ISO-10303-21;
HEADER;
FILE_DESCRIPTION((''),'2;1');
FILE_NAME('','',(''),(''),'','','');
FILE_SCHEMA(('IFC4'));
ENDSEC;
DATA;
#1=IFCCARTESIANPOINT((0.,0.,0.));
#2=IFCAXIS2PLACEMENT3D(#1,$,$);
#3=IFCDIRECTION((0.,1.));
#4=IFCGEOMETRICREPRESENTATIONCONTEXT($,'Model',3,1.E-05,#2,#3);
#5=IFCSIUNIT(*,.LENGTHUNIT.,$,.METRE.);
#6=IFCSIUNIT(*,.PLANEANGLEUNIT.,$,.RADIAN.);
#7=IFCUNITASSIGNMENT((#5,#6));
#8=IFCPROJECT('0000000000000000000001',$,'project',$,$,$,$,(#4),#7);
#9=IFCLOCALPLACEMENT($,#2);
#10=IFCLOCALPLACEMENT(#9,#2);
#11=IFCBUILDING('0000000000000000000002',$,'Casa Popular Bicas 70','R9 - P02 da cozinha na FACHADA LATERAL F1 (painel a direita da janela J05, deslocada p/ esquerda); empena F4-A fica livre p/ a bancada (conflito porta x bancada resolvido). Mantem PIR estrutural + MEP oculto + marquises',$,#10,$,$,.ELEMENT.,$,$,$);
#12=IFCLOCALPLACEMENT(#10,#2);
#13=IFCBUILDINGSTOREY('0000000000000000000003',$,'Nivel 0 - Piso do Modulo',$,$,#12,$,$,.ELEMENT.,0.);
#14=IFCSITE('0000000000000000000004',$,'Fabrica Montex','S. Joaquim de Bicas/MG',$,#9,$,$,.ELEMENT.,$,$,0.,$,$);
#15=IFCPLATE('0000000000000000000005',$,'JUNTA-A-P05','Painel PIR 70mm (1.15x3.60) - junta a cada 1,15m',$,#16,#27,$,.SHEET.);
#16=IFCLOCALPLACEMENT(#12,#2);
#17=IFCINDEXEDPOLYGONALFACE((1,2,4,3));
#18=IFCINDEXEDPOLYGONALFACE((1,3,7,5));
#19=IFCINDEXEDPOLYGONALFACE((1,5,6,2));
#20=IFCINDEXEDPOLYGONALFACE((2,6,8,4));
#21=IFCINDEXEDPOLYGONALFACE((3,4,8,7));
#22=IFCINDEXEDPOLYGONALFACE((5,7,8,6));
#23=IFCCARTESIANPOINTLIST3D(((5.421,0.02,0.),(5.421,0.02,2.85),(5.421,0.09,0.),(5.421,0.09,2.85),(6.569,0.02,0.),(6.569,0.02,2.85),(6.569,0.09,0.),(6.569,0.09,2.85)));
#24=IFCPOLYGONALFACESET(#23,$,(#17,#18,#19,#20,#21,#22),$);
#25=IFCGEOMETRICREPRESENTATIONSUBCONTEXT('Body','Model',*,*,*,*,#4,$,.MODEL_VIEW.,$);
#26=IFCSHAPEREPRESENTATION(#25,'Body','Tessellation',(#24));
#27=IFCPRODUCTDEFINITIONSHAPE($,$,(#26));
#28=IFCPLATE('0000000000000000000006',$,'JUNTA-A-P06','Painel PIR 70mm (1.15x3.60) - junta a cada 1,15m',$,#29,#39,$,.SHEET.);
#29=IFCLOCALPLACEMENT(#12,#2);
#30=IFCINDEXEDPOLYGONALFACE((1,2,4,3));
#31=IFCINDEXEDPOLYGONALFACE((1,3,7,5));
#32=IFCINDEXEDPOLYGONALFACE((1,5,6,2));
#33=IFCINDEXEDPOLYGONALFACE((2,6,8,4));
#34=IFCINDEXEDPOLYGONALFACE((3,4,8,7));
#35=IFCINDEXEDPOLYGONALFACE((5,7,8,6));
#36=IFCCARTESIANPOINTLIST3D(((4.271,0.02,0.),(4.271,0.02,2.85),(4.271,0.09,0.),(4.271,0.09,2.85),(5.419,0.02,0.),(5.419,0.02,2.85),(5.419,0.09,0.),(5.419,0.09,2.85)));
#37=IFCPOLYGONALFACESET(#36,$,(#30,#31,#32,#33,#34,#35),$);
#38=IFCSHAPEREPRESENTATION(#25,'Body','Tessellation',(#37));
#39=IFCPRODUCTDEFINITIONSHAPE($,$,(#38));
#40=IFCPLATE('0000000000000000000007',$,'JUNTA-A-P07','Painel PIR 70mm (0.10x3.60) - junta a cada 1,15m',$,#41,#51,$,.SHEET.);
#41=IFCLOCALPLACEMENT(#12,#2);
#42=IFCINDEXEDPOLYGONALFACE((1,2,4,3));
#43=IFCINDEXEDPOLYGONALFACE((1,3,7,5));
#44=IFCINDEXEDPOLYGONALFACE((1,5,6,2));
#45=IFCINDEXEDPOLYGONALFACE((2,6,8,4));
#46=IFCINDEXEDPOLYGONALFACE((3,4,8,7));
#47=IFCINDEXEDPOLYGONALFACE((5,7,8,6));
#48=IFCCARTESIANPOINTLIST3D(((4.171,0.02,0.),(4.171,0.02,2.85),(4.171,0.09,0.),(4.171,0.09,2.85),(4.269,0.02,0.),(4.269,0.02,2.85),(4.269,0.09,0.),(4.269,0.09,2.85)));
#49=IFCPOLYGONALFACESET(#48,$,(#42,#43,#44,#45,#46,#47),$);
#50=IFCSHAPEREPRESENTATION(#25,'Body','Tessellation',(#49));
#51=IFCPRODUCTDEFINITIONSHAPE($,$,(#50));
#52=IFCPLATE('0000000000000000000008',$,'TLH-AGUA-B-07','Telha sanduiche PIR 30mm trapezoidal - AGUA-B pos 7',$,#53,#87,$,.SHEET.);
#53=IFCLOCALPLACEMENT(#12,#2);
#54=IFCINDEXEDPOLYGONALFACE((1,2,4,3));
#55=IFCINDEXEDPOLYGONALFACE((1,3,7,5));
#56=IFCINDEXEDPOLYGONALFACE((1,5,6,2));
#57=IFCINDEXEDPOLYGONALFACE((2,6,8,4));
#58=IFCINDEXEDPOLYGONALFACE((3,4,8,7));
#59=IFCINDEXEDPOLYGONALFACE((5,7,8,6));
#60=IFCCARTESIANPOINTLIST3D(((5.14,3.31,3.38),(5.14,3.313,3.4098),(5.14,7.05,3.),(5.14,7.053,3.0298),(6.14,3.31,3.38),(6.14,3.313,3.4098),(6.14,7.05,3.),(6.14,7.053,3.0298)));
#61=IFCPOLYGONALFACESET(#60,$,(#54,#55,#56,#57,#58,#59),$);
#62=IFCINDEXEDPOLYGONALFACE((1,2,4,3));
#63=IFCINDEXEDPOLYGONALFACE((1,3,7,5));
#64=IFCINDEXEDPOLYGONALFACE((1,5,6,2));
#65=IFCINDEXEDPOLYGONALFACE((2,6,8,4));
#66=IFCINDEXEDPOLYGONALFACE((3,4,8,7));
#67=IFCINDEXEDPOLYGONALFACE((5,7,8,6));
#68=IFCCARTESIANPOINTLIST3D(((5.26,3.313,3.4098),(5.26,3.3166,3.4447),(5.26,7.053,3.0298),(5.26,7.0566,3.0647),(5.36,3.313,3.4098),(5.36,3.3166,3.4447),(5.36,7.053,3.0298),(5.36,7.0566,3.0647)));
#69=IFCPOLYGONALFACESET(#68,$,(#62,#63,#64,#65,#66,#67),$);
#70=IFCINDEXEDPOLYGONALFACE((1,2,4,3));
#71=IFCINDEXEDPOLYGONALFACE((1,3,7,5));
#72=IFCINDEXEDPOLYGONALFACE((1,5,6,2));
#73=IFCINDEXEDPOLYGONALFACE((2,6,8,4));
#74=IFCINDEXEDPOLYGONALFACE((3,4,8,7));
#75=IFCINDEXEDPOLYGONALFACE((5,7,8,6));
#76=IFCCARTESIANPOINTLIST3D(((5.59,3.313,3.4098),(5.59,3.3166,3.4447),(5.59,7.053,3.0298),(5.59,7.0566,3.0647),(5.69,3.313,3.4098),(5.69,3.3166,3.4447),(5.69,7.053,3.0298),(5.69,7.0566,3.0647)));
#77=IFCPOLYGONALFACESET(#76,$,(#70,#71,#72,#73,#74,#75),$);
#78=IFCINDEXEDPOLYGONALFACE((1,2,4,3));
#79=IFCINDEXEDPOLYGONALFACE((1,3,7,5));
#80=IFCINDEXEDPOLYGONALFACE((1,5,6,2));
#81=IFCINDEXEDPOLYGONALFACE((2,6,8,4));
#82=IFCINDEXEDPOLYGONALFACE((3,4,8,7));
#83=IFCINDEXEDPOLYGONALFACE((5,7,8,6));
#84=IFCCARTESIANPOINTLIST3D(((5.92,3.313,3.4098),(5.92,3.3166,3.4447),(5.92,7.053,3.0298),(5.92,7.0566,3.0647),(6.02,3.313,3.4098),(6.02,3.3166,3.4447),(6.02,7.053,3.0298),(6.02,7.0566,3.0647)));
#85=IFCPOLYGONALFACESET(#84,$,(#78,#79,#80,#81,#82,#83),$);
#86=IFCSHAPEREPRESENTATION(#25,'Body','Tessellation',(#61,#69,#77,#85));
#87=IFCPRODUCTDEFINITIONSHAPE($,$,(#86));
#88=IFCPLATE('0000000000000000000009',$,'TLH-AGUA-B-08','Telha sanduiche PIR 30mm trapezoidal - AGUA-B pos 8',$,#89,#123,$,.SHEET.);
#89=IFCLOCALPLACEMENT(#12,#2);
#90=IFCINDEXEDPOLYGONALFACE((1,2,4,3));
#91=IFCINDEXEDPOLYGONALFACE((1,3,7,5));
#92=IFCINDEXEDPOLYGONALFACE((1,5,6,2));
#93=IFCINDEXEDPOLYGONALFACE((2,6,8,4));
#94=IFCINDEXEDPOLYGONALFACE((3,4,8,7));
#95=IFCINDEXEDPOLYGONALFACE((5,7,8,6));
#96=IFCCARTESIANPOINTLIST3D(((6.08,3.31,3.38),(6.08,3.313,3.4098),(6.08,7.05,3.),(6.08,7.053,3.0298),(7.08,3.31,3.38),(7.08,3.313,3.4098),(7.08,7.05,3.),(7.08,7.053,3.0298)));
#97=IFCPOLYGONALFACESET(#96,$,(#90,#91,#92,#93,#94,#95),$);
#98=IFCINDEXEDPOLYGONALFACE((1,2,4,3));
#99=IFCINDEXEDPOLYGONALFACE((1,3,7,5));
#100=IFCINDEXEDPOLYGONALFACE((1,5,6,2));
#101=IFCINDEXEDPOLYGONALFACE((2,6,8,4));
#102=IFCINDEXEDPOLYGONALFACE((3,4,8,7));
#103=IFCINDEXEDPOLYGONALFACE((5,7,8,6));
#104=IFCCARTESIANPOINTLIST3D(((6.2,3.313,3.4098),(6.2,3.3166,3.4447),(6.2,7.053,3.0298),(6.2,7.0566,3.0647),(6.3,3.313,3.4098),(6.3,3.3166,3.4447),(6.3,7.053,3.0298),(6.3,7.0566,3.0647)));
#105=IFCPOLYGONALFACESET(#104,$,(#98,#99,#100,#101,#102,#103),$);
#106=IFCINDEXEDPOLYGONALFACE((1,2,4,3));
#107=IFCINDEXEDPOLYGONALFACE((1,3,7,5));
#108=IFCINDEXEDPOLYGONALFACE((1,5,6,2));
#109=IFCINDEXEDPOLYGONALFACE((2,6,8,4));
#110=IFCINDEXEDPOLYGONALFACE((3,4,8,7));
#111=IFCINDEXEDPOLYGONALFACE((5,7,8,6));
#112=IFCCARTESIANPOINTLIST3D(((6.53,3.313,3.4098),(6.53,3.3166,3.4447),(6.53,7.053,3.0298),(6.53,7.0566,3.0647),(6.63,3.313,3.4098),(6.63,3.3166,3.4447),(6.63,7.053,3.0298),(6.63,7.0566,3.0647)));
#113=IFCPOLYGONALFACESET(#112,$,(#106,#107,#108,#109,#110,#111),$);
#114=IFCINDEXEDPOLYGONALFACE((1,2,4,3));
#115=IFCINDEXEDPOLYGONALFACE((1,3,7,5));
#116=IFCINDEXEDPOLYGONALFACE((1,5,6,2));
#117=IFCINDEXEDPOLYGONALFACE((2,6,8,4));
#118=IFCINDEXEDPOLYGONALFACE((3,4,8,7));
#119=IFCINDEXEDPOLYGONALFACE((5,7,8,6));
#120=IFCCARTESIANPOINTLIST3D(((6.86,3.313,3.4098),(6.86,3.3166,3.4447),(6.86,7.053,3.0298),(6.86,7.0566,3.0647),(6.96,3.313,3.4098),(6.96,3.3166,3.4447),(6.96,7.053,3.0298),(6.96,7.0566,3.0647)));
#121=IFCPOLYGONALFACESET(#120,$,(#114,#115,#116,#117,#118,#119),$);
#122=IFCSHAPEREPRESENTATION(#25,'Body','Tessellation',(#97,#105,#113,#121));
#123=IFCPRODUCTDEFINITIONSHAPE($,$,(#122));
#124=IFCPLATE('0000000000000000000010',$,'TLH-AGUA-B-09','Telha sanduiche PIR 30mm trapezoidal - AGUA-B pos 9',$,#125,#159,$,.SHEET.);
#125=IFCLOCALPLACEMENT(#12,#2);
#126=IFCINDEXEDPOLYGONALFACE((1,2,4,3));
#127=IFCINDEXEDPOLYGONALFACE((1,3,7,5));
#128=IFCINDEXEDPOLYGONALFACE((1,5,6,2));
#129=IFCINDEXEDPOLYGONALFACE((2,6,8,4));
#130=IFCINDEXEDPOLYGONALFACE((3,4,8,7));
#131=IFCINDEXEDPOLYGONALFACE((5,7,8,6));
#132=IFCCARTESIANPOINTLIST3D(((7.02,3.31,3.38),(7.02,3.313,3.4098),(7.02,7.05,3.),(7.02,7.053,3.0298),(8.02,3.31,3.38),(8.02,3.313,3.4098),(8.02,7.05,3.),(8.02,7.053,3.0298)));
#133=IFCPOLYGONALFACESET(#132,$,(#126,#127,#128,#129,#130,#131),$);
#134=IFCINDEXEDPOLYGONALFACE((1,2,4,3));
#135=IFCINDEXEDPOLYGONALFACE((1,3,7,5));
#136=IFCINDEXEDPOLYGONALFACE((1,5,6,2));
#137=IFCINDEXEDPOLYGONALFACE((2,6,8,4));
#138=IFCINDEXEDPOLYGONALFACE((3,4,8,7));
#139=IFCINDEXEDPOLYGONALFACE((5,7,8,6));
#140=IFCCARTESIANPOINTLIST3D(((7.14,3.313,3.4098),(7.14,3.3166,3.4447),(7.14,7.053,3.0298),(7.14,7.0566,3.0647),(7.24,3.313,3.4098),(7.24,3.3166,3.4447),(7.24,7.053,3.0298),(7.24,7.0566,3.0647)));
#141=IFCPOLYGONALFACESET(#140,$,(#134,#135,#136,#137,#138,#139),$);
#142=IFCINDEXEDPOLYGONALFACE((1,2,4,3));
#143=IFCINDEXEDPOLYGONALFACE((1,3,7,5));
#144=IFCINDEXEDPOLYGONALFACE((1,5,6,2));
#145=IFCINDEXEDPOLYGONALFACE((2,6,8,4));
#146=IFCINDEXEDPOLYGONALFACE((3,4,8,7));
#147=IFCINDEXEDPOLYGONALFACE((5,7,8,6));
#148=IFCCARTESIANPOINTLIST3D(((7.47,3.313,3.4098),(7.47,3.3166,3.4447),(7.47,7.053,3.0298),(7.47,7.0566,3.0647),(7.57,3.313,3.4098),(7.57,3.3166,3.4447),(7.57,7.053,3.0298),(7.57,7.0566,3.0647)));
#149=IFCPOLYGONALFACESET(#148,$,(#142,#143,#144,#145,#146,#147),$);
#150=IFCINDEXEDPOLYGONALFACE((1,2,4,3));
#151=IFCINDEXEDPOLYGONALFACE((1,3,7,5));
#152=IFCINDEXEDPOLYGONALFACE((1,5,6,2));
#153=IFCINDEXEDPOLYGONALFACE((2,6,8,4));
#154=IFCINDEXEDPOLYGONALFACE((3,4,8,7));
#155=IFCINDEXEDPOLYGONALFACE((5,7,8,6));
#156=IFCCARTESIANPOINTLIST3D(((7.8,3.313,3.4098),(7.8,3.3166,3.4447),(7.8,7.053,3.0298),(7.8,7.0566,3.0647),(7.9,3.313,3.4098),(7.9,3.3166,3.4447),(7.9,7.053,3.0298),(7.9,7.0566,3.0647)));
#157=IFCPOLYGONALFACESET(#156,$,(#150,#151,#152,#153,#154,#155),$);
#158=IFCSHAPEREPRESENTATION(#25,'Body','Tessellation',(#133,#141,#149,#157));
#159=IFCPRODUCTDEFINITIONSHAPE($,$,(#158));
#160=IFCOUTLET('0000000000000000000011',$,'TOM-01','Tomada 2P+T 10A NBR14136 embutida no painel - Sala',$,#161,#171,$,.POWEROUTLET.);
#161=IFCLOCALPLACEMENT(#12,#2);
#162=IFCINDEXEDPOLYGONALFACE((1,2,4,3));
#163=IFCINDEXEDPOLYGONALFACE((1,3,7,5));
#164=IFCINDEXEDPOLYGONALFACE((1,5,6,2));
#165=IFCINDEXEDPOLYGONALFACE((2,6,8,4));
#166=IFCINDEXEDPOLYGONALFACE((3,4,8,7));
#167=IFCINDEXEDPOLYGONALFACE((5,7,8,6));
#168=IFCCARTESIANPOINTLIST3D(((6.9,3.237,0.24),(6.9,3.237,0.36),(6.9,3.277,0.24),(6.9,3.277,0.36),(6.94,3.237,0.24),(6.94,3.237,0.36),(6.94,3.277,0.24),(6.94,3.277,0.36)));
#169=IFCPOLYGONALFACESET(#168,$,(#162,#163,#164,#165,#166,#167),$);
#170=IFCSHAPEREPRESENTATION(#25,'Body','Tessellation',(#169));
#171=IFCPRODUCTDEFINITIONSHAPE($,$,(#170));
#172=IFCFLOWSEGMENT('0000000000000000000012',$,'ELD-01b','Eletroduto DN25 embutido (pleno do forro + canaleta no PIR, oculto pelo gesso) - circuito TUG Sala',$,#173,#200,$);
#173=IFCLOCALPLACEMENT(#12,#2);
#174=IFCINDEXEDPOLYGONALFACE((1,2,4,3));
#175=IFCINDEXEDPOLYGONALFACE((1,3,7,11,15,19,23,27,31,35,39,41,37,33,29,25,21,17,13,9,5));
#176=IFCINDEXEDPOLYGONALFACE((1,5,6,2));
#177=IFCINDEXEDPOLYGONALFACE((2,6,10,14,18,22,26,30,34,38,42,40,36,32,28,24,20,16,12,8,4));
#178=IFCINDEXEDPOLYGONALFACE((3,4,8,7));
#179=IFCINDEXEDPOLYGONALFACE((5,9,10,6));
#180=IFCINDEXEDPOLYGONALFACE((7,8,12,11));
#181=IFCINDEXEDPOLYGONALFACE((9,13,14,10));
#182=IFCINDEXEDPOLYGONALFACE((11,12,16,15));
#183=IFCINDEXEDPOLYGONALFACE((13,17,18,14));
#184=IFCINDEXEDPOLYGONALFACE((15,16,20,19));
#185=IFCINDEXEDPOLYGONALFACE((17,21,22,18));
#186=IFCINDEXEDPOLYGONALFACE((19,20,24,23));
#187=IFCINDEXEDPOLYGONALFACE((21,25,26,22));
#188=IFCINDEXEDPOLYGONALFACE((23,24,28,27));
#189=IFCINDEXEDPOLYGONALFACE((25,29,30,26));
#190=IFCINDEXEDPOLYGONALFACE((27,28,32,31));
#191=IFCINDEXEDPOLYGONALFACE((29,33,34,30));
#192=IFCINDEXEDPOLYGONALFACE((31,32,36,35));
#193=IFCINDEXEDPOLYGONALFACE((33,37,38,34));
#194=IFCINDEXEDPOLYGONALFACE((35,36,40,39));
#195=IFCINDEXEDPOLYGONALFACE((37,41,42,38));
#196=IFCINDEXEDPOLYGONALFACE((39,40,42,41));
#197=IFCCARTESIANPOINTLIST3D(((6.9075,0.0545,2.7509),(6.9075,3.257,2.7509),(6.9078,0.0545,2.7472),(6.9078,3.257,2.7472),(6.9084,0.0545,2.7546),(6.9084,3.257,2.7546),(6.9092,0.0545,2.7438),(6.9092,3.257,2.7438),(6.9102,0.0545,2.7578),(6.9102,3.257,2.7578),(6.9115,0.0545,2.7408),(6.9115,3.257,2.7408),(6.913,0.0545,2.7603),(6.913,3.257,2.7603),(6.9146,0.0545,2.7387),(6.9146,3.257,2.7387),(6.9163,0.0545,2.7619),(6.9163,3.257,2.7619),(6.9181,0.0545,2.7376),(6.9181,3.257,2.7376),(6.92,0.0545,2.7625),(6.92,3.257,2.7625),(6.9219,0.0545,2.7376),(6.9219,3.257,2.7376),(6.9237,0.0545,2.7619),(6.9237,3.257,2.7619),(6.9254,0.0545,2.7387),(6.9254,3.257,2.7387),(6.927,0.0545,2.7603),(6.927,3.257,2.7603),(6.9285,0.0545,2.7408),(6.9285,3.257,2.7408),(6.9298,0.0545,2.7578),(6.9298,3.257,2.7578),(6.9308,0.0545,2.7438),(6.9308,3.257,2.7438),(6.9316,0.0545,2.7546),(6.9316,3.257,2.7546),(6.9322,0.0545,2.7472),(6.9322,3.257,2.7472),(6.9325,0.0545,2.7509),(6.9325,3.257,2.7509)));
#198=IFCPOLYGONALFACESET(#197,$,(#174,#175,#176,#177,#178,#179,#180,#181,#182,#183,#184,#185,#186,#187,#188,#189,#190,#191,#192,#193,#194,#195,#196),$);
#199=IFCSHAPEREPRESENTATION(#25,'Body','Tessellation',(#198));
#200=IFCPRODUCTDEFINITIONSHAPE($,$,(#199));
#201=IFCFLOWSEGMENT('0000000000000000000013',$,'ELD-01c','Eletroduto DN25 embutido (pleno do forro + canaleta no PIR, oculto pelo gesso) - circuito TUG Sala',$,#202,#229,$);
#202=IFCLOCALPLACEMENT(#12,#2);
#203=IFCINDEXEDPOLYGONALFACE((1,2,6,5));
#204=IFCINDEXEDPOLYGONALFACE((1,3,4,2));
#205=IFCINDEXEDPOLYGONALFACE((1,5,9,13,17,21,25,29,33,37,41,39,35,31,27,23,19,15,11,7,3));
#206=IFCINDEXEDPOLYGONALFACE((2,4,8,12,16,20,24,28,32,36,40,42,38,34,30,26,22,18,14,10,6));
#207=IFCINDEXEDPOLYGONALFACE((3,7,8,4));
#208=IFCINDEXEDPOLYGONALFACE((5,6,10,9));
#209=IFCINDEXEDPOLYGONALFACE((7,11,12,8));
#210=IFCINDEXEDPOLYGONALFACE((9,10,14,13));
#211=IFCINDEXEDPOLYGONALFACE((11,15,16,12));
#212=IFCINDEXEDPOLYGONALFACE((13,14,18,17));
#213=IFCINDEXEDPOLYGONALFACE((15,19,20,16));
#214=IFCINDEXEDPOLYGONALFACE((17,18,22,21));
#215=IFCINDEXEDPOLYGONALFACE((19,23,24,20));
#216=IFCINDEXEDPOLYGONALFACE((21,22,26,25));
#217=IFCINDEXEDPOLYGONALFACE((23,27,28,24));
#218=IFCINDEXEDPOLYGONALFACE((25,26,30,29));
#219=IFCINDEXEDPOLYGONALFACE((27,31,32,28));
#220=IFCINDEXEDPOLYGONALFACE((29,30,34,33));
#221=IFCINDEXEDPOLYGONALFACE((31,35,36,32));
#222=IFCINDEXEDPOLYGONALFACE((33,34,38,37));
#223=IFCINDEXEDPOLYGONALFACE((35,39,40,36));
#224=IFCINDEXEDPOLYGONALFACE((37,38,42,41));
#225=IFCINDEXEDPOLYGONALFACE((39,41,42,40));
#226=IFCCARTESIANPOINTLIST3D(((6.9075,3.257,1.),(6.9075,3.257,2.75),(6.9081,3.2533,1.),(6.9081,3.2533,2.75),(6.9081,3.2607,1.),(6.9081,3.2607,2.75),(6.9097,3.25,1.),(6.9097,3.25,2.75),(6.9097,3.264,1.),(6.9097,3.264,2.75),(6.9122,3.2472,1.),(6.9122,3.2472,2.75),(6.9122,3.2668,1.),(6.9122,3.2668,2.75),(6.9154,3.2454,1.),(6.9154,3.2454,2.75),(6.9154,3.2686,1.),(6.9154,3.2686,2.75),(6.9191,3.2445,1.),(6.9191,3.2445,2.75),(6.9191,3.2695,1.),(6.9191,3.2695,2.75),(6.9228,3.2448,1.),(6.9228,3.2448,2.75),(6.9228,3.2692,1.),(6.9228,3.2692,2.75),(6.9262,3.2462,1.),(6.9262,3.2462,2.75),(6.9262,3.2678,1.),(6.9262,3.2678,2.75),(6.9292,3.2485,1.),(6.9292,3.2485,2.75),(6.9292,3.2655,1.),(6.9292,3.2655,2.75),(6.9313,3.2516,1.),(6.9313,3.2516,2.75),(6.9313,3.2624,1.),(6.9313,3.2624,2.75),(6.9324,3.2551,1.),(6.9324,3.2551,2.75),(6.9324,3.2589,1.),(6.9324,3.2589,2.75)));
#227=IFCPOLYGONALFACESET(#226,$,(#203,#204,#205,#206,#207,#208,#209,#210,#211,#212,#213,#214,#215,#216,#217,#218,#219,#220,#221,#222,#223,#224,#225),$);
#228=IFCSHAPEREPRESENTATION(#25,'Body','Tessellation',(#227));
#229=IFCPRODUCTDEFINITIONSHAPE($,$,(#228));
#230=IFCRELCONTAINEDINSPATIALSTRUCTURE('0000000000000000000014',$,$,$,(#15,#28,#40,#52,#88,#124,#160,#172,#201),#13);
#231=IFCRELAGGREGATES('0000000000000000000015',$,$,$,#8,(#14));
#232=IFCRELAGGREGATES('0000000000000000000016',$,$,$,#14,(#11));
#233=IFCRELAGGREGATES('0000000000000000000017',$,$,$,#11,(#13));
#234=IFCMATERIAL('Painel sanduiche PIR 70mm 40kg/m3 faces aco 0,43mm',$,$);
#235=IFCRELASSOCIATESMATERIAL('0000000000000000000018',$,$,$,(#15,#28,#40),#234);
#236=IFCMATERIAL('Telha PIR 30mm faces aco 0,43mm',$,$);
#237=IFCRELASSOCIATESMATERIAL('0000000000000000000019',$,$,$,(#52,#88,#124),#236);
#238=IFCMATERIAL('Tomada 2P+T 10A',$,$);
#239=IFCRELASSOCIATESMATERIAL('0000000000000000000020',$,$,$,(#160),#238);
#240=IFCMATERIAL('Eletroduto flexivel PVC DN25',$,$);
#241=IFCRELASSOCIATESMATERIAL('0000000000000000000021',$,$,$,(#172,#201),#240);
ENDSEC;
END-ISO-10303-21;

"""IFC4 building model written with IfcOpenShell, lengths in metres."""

from ifc_helpers import new_model, si_unit, direction, frame, frame_2d, origin, origin_2d, place, context, subcontext, project, spatial, rectangle, circle, extrude, material, element, save


model = new_model("IFC4")

# Units and contexts
model_context = context("Model", 3, precision=1e-05, world=origin(), true_north=direction((0.0, 1.0)))
body_context = subcontext(model_context, "Body", "Model", "MODEL_VIEW")
ifc_project = project(units=[si_unit("LENGTHUNIT", "METRE"), si_unit("PLANEANGLEUNIT", "RADIAN")], contexts=[model_context])

# Site, building, storey
site_placement = place(None, origin())
site = spatial("IfcSite", under=ifc_project, at=site_placement, Name="Fabrica Montex", Description="S. Joaquim de Bicas/MG", CompositionType="ELEMENT", RefElevation=0.0)
building_placement = place(site_placement, origin())
building = spatial("IfcBuilding", under=site, at=building_placement, Name="Casa Popular Bicas 70", Description="R9 - P02 da cozinha na FACHADA LATERAL F1 (painel a direita da janela J05, deslocada p/ esquerda); empena F4-A fica livre p/ a bancada (conflito porta x bancada resolvido). Mantem PIR estrutural + MEP oculto + marquises", CompositionType="ELEMENT")
storey_placement = place(building_placement, origin())
storey = spatial("IfcBuildingStorey", under=building, at=storey_placement, Name="Nivel 0 - Piso do Modulo", CompositionType="ELEMENT", Elevation=0.0)

# Shared definitions
ifc_material_1 = material(Name="Painel sanduiche PIR 70mm 40kg/m3 faces aco 0,43mm")

# Plates
for number, where, z_axis, x_axis, name in (
    (1, (6.569, 0.055, 0.0), (0.0, 0.0, 1.0), (-1.0, 0.0, 0.0), "JUNTA-A-P05"),
    (2, (5.419, 0.055, 0.0), (0.0, 0.0, 1.0), (-1.0, 0.0, 0.0), "JUNTA-A-P06"),
):
    element("IfcPlate", number, at=place(None, frame(where, z_axis=z_axis, x_axis=x_axis)), inside=storey, material=ifc_material_1, Name=name, Description="Painel PIR 70mm (1.15x3.60) - junta a cada 1,15m", PredefinedType="SHEET", context=body_context, shape_type="SweptSolid", body=[
        extrude(rectangle(XDim=1.148, YDim=0.07, at=frame_2d((0.574, 0.0))), origin(), (0.0, 0.0, 1.0), 2.85),
    ])
plate_1_placement = place(None, frame((4.269, 0.055, 0.0), z_axis=(0.0, 0.0, 1.0), x_axis=(-1.0, 0.0, 0.0)))
element("IfcPlate", 3, at=plate_1_placement, inside=storey, material=ifc_material_1, Name="JUNTA-A-P07", Description="Painel PIR 70mm (0.10x3.60) - junta a cada 1,15m", PredefinedType="SHEET", context=body_context, shape_type="SweptSolid", body=[
    extrude(rectangle(XDim=0.098, YDim=0.07, at=frame_2d((0.049, 0.0))), origin(), (0.0, 0.0, 1.0), 2.85),
])
ifc_material_2 = material(Name="Telha PIR 30mm faces aco 0,43mm")
for number, where, z_axis, x_axis, name, description in (
    (4, (5.14, 3.31, 3.38), (0.0, 0.101084, 0.994878), (1.0, 0.0, 0.0), "TLH-AGUA-B-07", "Telha sanduiche PIR 30mm trapezoidal - AGUA-B pos 7"),
    (5, (6.08, 3.31, 3.38), (0.0, 0.101084, 0.994878), (1.0, 0.0, 0.0), "TLH-AGUA-B-08", "Telha sanduiche PIR 30mm trapezoidal - AGUA-B pos 8"),
    (6, (7.02, 3.31, 3.38), (0.0, 0.101084, 0.994878), (1.0, 0.0, 0.0), "TLH-AGUA-B-09", "Telha sanduiche PIR 30mm trapezoidal - AGUA-B pos 9"),
):
    element("IfcPlate", number, at=place(storey_placement, frame(where, z_axis=z_axis, x_axis=x_axis)), inside=storey, material=ifc_material_2, Name=name, Description=description, PredefinedType="SHEET", context=body_context, shape_type="SweptSolid", body=[
        extrude(rectangle(XDim=1.0, YDim=3.7593, at=frame_2d((0.5, 1.8796))), origin(), (0.0, 0.0, 1.0), 0.03),
        extrude(rectangle(XDim=0.1, YDim=3.7593, at=frame_2d((0.17, 1.8796))), frame((0.0, 0.0, 0.03)), (0.0, 0.0, 1.0), 0.035),
        extrude(rectangle(XDim=0.1, YDim=3.7593, at=frame_2d((0.5, 1.8796))), frame((0.0, 0.0, 0.03)), (0.0, 0.0, 1.0), 0.035),
        extrude(rectangle(XDim=0.1, YDim=3.7593, at=frame_2d((0.83, 1.8796))), frame((0.0, 0.0, 0.03)), (0.0, 0.0, 1.0), 0.035),
    ])

# Outlet
ifc_material_3 = material(Name="Tomada 2P+T 10A")
outlet_1_placement = place(None, frame((6.94, 3.277, 0.24), z_axis=(0.0, 0.0, 1.0), x_axis=(-1.0, 0.0, 0.0)))
element("IfcOutlet", 7, at=outlet_1_placement, inside=storey, material=ifc_material_3, Name="TOM-01", Description="Tomada 2P+T 10A NBR14136 embutida no painel - Sala", PredefinedType="POWEROUTLET", context=body_context, shape_type="SweptSolid", body=[
    extrude(rectangle(XDim=0.04, YDim=0.04, at=frame_2d((0.02, 0.02))), origin(), (0.0, 0.0, 1.0), 0.12),
])

# Flow segments
ifc_material_4 = material(Name="Eletroduto flexivel PVC DN25")
flow_segment_1_placement = place(None, frame((6.92, 0.0545, 2.75), z_axis=(0.0, 1.0, 0.0), x_axis=(0.0, 0.0, 1.0)))
element("IfcFlowSegment", 8, at=flow_segment_1_placement, inside=storey, material=ifc_material_4, Name="ELD-01b", Description="Eletroduto DN25 embutido (pleno do forro + canaleta no PIR, oculto pelo gesso) - circuito TUG Sala", context=body_context, shape_type="SweptSolid", body=[
    extrude(circle(Radius=0.0125, at=origin_2d()), origin(), (0.0, 0.0, 1.0), 3.2025),
])
flow_segment_2_placement = place(None, frame((6.92, 3.257, 2.75), z_axis=(0.0, 0.0, -1.0), x_axis=(-1.0, 0.0, 0.0)))
element("IfcFlowSegment", 9, at=flow_segment_2_placement, inside=storey, material=ifc_material_4, Name="ELD-01c", Description="Eletroduto DN25 embutido (pleno do forro + canaleta no PIR, oculto pelo gesso) - circuito TUG Sala", context=body_context, shape_type="SweptSolid", body=[
    extrude(circle(Radius=0.0125, at=origin_2d()), origin(), (0.0, 0.0, 1.0), 1.75),
])

save(model, "model.ifc")
